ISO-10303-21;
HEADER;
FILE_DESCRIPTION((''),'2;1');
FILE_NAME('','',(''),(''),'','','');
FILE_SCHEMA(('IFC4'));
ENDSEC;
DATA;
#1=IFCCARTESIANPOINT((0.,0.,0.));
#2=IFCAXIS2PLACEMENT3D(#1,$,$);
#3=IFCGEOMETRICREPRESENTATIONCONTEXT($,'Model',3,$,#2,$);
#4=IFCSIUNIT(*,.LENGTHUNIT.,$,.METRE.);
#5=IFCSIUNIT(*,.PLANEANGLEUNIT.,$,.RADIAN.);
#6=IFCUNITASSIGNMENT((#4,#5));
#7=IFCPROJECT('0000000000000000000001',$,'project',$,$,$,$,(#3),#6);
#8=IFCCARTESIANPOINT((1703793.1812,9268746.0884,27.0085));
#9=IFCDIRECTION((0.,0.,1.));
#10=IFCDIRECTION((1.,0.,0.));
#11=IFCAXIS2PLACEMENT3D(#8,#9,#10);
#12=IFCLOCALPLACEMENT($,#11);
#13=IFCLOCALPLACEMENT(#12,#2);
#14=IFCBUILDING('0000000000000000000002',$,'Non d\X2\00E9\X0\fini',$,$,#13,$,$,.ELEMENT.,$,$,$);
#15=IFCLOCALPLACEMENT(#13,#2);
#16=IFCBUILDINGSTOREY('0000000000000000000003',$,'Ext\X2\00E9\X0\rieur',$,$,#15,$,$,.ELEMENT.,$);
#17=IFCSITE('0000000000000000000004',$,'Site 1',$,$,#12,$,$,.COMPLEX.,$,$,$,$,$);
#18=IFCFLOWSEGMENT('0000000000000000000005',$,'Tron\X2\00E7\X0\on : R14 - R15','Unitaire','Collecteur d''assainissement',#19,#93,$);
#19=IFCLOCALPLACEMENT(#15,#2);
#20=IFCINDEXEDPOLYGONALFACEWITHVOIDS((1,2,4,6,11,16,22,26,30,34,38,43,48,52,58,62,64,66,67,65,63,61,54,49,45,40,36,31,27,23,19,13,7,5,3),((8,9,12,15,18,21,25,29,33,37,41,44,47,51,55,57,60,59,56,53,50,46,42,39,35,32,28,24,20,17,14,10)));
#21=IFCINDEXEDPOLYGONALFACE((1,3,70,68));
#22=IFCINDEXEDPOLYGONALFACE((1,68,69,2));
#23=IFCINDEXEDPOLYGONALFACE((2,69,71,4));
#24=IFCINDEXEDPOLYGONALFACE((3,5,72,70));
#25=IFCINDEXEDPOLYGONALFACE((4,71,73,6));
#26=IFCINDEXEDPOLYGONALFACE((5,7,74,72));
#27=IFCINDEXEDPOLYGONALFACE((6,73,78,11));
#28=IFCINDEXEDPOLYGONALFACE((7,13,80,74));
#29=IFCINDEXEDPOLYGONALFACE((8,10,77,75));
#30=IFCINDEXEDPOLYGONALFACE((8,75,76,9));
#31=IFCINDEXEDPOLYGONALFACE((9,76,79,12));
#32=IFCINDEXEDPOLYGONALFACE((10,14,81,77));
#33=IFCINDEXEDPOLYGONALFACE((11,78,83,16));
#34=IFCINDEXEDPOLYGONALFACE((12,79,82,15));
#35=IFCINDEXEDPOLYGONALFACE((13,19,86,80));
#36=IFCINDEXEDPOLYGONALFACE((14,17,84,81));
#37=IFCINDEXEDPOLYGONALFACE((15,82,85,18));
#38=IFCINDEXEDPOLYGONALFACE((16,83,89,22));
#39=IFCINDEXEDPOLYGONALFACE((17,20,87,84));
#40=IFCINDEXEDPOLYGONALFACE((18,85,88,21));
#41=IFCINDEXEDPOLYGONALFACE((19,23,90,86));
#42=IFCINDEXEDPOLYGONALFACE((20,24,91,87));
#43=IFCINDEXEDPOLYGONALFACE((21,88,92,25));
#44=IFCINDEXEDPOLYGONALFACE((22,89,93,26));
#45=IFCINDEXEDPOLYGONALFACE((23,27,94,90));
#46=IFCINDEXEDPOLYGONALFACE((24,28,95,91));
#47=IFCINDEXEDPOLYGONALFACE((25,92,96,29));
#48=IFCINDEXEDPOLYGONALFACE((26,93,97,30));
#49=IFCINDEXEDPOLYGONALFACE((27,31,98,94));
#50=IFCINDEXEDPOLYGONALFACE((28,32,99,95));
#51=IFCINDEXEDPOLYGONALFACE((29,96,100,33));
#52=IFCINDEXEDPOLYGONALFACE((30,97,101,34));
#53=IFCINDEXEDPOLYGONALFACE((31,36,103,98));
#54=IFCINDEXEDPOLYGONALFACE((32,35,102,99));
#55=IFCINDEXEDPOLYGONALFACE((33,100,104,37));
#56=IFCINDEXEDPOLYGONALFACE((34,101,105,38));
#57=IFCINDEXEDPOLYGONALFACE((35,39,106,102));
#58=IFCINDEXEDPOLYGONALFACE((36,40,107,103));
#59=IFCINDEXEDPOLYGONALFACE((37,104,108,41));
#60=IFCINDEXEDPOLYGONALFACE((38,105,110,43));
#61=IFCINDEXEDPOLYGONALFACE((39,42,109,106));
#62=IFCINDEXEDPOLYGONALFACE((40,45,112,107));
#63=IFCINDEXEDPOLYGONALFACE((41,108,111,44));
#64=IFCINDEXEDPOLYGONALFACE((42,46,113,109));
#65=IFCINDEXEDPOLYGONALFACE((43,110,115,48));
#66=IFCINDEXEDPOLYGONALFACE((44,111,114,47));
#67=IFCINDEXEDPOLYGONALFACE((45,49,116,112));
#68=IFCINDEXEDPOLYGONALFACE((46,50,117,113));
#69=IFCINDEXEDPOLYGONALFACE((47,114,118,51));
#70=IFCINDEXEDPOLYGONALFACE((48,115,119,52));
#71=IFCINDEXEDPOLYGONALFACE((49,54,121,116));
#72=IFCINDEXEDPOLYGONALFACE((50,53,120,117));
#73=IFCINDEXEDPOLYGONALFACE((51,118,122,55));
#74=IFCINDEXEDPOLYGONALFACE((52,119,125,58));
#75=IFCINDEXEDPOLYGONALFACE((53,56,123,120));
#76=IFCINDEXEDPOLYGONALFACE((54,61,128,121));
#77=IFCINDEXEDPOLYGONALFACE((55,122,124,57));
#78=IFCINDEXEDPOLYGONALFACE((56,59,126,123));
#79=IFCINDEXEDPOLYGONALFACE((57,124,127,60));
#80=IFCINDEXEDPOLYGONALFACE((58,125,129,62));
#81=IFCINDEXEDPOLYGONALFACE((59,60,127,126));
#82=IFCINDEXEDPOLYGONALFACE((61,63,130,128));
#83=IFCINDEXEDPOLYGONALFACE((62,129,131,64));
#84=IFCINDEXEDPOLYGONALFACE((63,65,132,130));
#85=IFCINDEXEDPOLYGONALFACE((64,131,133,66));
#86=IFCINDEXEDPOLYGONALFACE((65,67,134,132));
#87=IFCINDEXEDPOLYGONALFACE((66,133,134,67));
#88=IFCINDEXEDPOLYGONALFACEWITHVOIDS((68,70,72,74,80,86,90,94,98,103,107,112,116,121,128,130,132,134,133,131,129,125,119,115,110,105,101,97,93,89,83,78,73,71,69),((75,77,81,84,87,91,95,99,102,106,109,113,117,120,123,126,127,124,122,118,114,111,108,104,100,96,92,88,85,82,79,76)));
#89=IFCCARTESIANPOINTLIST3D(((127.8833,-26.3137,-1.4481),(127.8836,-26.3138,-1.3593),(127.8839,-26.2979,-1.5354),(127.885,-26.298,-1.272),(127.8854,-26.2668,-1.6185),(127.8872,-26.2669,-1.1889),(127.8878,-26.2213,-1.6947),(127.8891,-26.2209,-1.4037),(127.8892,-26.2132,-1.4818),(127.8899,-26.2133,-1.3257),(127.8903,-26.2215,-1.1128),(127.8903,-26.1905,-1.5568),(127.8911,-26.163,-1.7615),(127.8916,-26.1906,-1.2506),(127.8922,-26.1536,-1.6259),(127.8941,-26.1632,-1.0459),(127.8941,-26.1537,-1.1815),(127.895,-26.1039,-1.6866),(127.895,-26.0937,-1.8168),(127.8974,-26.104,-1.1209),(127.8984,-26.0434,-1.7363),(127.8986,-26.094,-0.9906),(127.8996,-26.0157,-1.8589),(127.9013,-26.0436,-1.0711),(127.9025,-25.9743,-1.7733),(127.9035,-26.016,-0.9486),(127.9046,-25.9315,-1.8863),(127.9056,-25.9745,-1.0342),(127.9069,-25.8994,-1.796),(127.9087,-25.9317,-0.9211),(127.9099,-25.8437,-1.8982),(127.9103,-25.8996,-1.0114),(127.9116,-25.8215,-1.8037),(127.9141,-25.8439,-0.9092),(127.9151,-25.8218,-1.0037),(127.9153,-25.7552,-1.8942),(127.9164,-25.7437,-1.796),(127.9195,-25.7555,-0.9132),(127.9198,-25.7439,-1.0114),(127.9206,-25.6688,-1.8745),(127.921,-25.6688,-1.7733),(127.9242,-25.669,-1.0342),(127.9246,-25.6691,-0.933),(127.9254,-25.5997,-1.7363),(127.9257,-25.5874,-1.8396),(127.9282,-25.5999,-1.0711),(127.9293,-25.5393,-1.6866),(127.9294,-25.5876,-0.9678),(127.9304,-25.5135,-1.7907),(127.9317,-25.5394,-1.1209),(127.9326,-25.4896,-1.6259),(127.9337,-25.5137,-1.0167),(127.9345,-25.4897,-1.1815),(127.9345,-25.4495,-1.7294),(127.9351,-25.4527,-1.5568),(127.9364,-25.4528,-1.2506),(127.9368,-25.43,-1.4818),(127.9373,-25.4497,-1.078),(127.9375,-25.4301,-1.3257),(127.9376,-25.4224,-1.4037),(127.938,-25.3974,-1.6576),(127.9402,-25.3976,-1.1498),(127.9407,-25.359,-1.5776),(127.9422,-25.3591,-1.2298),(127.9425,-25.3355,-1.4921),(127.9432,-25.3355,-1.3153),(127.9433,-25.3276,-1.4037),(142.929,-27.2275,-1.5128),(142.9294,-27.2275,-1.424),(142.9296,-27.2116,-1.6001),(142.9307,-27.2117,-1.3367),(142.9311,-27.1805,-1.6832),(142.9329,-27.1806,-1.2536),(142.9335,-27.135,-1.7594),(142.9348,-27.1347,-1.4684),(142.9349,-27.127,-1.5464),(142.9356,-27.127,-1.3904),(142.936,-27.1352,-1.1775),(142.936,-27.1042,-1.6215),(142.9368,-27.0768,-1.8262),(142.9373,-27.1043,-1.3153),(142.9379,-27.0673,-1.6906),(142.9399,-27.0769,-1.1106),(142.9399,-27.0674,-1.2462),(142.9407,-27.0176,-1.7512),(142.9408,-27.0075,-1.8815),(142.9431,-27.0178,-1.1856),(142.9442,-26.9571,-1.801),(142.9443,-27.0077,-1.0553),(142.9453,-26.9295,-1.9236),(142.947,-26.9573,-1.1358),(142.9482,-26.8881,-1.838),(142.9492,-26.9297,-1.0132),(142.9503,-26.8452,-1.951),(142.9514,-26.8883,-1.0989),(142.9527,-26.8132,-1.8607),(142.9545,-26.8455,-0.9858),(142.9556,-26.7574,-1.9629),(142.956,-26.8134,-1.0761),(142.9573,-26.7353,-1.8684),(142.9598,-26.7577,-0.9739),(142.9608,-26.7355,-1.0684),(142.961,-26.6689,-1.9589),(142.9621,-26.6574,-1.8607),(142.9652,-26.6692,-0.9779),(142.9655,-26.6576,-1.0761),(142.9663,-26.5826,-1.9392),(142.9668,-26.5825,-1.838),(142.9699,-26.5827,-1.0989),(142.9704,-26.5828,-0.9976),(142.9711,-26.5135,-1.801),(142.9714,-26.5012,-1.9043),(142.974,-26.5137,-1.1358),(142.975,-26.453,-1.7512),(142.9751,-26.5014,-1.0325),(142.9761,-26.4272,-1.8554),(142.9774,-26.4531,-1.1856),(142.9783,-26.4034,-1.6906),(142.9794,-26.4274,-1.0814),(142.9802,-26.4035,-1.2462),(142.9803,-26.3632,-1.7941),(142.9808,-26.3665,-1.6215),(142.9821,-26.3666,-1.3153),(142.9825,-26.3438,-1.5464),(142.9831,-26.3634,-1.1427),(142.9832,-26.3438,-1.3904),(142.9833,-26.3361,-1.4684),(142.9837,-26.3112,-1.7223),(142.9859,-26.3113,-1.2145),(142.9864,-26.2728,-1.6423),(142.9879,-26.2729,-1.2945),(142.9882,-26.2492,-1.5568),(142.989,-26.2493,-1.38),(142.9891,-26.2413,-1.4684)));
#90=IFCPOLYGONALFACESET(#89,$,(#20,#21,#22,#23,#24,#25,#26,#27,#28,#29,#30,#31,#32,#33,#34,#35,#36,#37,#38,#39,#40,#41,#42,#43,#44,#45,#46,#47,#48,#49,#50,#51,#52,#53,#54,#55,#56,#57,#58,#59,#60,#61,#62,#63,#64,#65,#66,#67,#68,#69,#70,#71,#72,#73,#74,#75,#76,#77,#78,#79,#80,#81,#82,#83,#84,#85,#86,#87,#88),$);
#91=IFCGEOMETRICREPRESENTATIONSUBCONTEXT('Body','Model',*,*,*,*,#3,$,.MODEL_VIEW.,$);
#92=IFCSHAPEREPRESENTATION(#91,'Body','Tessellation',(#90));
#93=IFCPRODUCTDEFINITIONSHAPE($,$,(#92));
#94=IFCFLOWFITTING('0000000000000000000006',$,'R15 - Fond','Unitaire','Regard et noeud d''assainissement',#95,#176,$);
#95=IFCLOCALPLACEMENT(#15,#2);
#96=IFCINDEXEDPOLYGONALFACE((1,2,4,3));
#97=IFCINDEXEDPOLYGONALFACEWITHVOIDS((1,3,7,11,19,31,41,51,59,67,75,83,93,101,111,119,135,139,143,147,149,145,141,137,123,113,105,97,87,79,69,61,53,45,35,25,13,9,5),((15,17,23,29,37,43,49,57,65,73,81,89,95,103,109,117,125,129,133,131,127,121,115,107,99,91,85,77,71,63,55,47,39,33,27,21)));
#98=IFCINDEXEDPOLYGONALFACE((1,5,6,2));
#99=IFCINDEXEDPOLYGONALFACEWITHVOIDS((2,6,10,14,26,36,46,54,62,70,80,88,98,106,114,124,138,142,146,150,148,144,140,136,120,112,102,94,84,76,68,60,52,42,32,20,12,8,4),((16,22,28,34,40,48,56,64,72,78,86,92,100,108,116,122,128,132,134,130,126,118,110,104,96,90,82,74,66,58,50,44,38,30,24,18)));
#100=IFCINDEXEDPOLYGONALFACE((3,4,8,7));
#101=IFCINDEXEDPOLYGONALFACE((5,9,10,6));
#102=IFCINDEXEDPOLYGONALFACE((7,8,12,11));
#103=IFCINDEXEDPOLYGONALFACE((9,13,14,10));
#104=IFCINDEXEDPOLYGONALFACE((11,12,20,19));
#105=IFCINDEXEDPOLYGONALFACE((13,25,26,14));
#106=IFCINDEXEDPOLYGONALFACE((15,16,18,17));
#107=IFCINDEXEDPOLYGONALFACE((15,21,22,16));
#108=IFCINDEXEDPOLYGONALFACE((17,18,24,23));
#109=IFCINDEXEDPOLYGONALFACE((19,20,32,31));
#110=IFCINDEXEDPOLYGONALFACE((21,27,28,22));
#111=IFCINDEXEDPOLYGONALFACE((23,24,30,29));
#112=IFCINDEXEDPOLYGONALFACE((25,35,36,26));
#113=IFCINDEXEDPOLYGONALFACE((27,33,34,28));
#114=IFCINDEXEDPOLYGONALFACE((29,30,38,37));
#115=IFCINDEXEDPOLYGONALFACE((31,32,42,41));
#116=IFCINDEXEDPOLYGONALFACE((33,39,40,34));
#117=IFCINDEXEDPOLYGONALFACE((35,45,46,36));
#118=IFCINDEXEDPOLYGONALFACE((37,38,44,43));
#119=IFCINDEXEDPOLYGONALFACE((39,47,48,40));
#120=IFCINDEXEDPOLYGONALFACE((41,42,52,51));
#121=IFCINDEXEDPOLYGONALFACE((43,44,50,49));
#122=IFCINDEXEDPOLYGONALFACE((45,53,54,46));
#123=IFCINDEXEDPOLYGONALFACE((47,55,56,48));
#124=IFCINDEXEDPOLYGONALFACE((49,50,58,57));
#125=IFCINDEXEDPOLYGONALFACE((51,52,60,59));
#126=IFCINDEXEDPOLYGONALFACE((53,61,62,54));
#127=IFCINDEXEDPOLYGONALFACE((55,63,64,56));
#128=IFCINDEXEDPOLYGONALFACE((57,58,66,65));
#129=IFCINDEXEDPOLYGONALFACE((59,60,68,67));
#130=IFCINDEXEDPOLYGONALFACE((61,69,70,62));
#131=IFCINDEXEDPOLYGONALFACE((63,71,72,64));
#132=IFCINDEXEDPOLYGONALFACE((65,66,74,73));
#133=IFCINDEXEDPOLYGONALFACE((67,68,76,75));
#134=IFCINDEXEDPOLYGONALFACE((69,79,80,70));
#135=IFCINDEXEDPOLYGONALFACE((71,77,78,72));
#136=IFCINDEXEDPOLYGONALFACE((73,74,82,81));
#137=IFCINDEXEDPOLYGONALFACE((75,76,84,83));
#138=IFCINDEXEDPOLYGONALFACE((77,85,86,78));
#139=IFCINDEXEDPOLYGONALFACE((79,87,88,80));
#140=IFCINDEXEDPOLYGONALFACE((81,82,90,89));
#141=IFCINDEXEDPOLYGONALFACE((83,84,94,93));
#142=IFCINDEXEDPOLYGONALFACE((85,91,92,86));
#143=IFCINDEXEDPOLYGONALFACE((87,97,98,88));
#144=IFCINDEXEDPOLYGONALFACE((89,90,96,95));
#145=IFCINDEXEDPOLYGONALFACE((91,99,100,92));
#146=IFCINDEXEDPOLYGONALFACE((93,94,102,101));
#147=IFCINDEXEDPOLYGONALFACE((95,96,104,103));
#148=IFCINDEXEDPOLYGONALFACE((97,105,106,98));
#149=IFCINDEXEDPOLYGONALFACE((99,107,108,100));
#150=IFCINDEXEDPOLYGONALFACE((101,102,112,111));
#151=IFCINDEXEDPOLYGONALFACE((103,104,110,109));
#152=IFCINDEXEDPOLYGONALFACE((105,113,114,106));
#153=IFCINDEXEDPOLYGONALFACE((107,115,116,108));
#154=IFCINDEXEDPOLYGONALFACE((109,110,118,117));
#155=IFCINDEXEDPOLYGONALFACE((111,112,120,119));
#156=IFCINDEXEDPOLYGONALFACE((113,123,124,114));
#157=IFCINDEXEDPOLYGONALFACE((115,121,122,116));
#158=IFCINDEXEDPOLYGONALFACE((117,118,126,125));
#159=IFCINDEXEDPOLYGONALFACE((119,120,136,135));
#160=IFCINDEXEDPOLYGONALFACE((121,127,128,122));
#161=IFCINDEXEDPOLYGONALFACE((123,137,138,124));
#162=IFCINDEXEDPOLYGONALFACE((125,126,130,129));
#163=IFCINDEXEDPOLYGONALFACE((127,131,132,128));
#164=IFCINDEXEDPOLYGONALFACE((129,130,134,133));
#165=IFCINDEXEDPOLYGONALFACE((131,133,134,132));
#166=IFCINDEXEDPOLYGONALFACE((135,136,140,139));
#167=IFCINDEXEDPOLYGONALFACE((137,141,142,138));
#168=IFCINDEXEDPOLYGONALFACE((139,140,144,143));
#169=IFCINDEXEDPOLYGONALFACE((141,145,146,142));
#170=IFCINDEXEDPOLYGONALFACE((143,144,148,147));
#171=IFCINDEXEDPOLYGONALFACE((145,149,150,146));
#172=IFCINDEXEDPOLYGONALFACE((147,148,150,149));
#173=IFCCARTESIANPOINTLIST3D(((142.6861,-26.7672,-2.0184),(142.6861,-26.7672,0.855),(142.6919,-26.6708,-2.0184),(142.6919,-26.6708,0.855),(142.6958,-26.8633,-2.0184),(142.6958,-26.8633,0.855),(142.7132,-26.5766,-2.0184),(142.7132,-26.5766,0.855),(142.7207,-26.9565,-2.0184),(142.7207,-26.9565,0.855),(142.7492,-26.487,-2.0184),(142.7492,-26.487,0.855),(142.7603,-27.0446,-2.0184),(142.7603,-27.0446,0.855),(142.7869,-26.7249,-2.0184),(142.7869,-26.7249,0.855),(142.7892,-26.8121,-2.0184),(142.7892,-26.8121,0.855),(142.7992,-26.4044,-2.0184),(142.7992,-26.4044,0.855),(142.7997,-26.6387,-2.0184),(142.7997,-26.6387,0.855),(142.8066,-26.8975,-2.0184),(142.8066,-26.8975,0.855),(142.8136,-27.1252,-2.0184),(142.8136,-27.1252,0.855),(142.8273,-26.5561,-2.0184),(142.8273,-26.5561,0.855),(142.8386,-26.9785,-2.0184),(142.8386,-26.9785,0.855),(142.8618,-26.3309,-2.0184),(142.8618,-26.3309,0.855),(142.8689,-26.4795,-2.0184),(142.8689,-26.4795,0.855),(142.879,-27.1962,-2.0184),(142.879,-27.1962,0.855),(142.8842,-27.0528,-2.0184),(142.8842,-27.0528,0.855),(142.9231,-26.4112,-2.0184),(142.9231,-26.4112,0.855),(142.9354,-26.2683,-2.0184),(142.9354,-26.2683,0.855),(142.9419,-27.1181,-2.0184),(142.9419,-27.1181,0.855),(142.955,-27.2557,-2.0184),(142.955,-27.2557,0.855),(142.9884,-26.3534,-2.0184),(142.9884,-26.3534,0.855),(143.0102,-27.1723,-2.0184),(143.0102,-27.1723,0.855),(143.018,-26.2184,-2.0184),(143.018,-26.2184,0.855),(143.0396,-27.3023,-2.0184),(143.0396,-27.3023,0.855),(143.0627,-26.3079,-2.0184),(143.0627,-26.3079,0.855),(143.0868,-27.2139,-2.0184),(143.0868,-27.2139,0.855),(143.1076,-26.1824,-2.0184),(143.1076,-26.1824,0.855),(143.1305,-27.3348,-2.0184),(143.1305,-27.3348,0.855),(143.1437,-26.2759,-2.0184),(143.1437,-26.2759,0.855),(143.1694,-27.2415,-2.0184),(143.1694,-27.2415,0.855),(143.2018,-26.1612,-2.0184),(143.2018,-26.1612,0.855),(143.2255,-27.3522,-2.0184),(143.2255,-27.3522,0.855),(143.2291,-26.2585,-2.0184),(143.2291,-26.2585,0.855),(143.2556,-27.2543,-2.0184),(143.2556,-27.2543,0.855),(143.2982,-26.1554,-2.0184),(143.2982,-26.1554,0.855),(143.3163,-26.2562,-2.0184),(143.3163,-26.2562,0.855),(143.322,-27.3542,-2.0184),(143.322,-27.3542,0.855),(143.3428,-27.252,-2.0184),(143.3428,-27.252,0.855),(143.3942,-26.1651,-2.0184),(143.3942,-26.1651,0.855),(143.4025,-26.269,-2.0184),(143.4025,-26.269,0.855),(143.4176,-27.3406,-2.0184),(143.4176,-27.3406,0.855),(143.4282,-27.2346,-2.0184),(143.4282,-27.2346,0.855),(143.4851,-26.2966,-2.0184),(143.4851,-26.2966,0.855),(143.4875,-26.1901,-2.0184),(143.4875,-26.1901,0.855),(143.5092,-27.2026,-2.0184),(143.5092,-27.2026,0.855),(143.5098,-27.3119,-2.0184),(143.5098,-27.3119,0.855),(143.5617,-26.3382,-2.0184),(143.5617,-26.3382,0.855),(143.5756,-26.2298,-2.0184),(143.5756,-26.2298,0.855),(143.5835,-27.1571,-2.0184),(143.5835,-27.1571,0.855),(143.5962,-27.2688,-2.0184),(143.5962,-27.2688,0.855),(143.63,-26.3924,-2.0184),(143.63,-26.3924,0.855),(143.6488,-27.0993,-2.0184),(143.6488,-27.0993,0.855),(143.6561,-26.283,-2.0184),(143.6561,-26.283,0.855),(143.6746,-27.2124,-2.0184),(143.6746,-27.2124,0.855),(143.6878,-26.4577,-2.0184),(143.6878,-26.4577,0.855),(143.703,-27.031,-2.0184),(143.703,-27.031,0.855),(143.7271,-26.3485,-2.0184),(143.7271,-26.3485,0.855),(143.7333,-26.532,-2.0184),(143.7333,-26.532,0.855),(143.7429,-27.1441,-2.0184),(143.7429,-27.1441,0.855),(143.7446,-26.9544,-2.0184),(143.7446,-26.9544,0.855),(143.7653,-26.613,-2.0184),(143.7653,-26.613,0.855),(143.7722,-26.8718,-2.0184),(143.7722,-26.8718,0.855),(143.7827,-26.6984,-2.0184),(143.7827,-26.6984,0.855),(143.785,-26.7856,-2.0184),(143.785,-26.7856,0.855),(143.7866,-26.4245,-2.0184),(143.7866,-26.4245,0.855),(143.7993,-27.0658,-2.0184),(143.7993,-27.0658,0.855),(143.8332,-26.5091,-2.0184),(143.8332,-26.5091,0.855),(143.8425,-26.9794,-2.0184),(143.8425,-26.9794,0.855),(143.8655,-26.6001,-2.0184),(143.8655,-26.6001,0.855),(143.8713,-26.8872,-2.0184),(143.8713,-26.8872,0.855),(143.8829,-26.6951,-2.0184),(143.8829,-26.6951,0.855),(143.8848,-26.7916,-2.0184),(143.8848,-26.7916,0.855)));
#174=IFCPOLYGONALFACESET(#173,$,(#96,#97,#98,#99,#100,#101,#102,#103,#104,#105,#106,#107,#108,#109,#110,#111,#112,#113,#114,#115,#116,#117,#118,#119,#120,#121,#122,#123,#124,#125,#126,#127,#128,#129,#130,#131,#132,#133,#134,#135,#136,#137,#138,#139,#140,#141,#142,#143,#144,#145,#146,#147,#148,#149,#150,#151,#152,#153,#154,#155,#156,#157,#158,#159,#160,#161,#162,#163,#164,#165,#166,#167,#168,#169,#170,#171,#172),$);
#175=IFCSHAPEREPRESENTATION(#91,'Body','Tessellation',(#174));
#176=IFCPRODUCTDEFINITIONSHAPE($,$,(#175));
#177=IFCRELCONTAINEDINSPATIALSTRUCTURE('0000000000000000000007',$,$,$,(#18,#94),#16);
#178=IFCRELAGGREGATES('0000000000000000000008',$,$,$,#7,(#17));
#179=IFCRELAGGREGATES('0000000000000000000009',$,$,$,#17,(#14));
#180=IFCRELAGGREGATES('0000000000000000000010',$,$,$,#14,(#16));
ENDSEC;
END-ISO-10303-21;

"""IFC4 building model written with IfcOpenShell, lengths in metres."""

from ifc_helpers import new_model, si_unit, frame, origin, origin_2d, place, context, subcontext, project, spatial, hollow_circle, extrude, element, save


model = new_model("IFC4")

# Units and contexts
model_context = context("Model", 3, world=origin())
body_context = subcontext(model_context, "Body", "Model", "MODEL_VIEW")
ifc_project = project(units=[si_unit("LENGTHUNIT", "METRE"), si_unit("PLANEANGLEUNIT", "RADIAN")], contexts=[model_context])

# Site, building, storey
site_placement = place(None, frame((1703793.1812, 9268746.0884, 27.0085), z_axis=(0.0, 0.0, 1.0), x_axis=(1.0, 0.0, 0.0)))
site = spatial("IfcSite", under=ifc_project, at=site_placement, Name="Site 1", CompositionType="COMPLEX")
building_placement = place(site_placement, origin())
building = spatial("IfcBuilding", under=site, at=building_placement, Name="Non défini", CompositionType="ELEMENT")
storey_placement = place(building_placement, origin())
storey = spatial("IfcBuildingStorey", under=building, at=storey_placement, Name="Extérieur", CompositionType="ELEMENT")

# Flow segment
flow_segment_1_placement = place(storey_placement, origin())
element("IfcFlowSegment", 1, at=flow_segment_1_placement, inside=storey, Name="Tronçon : R14 - R15", Description="Unitaire", ObjectType="Collecteur d'assainissement", context=body_context, shape_type="SweptSolid", body=[
    extrude(hollow_circle(Radius=0.495, WallThickness=0.095, at=origin_2d()), frame((127.9133, -25.8217, -1.4037), z_axis=(0.998152, -0.060619, -0.004292), x_axis=(0.06062, 0.998161, 0.0)), (0.0, 0.0, 1.0), 15.0736),
])

# Flow fitting
flow_fitting_1_placement = place(storey_placement, origin())
element("IfcFlowFitting", 2, at=flow_fitting_1_placement, inside=storey, Name="R15 - Fond", Description="Unitaire", ObjectType="Regard et noeud d'assainissement", context=body_context, shape_type="SweptSolid", body=[
    extrude(hollow_circle(Radius=0.6, WallThickness=0.1, at=origin_2d()), frame((143.286, -26.7553, -2.0184), z_axis=(0.0, 0.0, 1.0), x_axis=(0.998161, -0.06062, 0.0)), (0.0, 0.0, 1.0), 2.8734),
])

save(model, "model.ifc")
